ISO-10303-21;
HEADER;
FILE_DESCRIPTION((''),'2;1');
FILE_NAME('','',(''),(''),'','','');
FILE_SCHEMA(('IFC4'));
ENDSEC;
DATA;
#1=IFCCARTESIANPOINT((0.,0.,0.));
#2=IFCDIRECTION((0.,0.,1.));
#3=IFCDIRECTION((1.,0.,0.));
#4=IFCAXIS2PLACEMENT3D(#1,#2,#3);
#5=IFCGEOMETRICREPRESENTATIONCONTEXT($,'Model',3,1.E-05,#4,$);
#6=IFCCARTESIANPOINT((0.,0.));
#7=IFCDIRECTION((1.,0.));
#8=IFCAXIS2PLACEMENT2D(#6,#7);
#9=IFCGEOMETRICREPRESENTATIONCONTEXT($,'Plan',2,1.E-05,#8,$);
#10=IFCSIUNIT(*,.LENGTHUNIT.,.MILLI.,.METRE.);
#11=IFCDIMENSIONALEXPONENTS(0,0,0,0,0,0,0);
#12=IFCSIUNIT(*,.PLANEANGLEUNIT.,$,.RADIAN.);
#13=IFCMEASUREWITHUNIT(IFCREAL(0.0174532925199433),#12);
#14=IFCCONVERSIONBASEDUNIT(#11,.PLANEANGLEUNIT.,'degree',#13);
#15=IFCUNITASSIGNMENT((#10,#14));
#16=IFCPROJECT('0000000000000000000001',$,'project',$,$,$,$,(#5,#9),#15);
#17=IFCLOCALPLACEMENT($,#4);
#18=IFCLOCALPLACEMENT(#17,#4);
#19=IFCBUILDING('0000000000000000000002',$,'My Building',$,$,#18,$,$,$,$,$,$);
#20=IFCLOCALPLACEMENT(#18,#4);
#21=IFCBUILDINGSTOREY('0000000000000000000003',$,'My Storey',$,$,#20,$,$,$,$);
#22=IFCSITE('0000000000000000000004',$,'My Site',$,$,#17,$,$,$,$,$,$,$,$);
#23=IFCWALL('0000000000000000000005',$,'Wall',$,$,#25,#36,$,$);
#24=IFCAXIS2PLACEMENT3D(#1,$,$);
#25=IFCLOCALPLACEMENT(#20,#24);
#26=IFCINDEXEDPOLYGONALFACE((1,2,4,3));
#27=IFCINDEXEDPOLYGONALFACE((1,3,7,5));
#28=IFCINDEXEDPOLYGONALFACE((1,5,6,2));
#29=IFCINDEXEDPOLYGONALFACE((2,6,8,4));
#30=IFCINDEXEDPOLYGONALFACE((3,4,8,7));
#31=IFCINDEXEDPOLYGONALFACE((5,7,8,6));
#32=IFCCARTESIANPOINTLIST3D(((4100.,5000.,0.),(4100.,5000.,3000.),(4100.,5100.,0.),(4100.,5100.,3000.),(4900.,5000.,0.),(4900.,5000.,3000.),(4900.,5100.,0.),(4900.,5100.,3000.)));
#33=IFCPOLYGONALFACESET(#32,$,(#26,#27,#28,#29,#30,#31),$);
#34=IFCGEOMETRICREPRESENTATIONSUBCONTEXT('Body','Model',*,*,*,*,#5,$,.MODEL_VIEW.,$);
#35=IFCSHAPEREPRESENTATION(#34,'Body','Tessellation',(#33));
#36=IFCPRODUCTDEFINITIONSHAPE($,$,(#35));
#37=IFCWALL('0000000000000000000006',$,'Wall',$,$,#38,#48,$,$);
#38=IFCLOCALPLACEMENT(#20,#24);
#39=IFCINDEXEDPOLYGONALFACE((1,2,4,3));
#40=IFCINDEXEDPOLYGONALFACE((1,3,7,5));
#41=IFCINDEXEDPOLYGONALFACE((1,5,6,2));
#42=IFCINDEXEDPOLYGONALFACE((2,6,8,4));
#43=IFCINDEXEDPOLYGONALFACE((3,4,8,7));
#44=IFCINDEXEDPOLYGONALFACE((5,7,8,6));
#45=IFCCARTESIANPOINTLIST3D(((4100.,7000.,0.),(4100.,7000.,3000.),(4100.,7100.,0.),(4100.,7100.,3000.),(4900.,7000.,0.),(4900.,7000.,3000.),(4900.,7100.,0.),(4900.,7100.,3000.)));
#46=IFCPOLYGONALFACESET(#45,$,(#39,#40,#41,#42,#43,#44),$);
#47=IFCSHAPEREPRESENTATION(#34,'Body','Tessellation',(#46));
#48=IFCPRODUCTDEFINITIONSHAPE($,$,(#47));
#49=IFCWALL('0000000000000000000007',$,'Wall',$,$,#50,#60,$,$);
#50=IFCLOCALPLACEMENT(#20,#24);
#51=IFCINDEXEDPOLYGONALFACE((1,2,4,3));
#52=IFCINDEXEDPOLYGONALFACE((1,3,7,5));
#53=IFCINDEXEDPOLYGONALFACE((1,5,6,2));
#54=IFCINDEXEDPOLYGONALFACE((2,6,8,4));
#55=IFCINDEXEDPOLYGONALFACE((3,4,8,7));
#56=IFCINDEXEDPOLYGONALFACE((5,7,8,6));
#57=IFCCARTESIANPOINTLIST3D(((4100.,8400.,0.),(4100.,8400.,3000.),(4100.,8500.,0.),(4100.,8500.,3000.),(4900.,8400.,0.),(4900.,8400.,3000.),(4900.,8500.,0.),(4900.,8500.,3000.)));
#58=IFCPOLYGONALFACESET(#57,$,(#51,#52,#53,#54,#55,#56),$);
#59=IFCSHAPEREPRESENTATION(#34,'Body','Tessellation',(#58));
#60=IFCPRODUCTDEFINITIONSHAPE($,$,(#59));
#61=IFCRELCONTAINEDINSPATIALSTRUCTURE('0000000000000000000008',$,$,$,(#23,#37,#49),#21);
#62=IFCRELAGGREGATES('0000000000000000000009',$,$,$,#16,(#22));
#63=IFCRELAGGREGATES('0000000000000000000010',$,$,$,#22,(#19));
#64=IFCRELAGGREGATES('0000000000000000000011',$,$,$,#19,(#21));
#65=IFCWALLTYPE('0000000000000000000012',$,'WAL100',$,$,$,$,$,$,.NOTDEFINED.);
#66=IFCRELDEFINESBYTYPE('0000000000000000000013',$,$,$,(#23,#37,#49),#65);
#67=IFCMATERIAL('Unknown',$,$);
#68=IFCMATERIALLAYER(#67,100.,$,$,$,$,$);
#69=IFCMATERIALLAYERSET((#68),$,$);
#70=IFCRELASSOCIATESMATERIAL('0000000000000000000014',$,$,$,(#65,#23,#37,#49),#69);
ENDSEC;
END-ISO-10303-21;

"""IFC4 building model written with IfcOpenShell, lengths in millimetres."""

from ifc_helpers import new_model, entity, si_unit, converted_unit, frame, origin_with_axes, origin_2d_with_axis, place, context, subcontext, project, spatial, indexed_curve, outline, extrude, material, layer, layer_set, layer_usage, type_object, element, save


model = new_model("IFC4")

# Units and contexts
model_context = context("Model", 3, precision=1e-05, world=origin_with_axes())
plan_context = context("Plan", 2, precision=1e-05, world=origin_2d_with_axis())
body_context = subcontext(model_context, "Body", "Model", "MODEL_VIEW")
ifc_project = project(units=[si_unit("LENGTHUNIT", "METRE", prefix="MILLI"), converted_unit("PLANEANGLEUNIT", "degree", entity("IfcReal", 0.0174532925199433), si_unit("PLANEANGLEUNIT", "RADIAN"), dimensions=[0, 0, 0, 0, 0, 0, 0])], contexts=[model_context, plan_context])

# Site, building, storey
site_placement = place(None, origin_with_axes())
site = spatial("IfcSite", under=ifc_project, at=site_placement, Name="My Site")
building_placement = place(site_placement, origin_with_axes())
building = spatial("IfcBuilding", under=site, at=building_placement, Name="My Building")
storey_placement = place(building_placement, origin_with_axes())
storey = spatial("IfcBuildingStorey", under=building, at=storey_placement, Name="My Storey")

# Walls
ifc_material = material(Name="Unknown")
ifc_layer = layer(ifc_material, 100.0)
ifc_layer_set = layer_set([ifc_layer])
wall_type = type_object("IfcWallType", Name="WAL100", PredefinedType="NOTDEFINED", material=ifc_layer_set)
ifc_layer_usage_1 = layer_usage(ifc_layer_set, "AXIS2", "POSITIVE", 0.0)
wall_1_placement = place(storey_placement, frame((4100.0, 5000.0, 0.0), z_axis=(0.0, 0.0, 1.0), x_axis=(1.0, 0.0, 0.0)))
element("IfcWall", 1, at=wall_1_placement, inside=storey, type_object=wall_type, material=ifc_layer_usage_1, Name="Wall", context=body_context, shape_type="SweptSolid", body=[
    extrude(outline(indexed_curve([(0.0, 0.0), (0.0, 100.0), (800.0, 100.0), (800.0, 0.0), (0.0, 0.0)], self_intersect=False)), origin_with_axes(), (0.0, 0.0, 1.0), 3000.0),
])
ifc_layer_usage_2 = layer_usage(ifc_layer_set, "AXIS2", "POSITIVE", 0.0)
wall_2_placement = place(storey_placement, frame((4100.0, 7000.0, 0.0), z_axis=(0.0, 0.0, 1.0), x_axis=(1.0, 0.0, 0.0)))
element("IfcWall", 2, at=wall_2_placement, inside=storey, type_object=wall_type, material=ifc_layer_usage_2, Name="Wall", context=body_context, shape_type="SweptSolid", body=[
    extrude(outline(indexed_curve([(0.0, 0.0), (0.0, 100.0), (800.0, 100.0), (800.0, 0.0), (0.0, 0.0)], self_intersect=False)), origin_with_axes(), (0.0, 0.0, 1.0), 3000.0),
])
ifc_layer_usage_3 = layer_usage(ifc_layer_set, "AXIS2", "POSITIVE", 0.0)
wall_3_placement = place(storey_placement, frame((4100.0, 8400.0, 0.0), z_axis=(0.0, 0.0, 1.0), x_axis=(1.0, 0.0, 0.0)))
element("IfcWall", 3, at=wall_3_placement, inside=storey, type_object=wall_type, material=ifc_layer_usage_3, Name="Wall", context=body_context, shape_type="SweptSolid", body=[
    extrude(outline(indexed_curve([(0.0, 0.0), (0.0, 100.0), (800.0, 100.0), (800.0, 0.0), (0.0, 0.0)], self_intersect=False)), origin_with_axes(), (0.0, 0.0, 1.0), 3000.0),
])

save(model, "model.ifc")
